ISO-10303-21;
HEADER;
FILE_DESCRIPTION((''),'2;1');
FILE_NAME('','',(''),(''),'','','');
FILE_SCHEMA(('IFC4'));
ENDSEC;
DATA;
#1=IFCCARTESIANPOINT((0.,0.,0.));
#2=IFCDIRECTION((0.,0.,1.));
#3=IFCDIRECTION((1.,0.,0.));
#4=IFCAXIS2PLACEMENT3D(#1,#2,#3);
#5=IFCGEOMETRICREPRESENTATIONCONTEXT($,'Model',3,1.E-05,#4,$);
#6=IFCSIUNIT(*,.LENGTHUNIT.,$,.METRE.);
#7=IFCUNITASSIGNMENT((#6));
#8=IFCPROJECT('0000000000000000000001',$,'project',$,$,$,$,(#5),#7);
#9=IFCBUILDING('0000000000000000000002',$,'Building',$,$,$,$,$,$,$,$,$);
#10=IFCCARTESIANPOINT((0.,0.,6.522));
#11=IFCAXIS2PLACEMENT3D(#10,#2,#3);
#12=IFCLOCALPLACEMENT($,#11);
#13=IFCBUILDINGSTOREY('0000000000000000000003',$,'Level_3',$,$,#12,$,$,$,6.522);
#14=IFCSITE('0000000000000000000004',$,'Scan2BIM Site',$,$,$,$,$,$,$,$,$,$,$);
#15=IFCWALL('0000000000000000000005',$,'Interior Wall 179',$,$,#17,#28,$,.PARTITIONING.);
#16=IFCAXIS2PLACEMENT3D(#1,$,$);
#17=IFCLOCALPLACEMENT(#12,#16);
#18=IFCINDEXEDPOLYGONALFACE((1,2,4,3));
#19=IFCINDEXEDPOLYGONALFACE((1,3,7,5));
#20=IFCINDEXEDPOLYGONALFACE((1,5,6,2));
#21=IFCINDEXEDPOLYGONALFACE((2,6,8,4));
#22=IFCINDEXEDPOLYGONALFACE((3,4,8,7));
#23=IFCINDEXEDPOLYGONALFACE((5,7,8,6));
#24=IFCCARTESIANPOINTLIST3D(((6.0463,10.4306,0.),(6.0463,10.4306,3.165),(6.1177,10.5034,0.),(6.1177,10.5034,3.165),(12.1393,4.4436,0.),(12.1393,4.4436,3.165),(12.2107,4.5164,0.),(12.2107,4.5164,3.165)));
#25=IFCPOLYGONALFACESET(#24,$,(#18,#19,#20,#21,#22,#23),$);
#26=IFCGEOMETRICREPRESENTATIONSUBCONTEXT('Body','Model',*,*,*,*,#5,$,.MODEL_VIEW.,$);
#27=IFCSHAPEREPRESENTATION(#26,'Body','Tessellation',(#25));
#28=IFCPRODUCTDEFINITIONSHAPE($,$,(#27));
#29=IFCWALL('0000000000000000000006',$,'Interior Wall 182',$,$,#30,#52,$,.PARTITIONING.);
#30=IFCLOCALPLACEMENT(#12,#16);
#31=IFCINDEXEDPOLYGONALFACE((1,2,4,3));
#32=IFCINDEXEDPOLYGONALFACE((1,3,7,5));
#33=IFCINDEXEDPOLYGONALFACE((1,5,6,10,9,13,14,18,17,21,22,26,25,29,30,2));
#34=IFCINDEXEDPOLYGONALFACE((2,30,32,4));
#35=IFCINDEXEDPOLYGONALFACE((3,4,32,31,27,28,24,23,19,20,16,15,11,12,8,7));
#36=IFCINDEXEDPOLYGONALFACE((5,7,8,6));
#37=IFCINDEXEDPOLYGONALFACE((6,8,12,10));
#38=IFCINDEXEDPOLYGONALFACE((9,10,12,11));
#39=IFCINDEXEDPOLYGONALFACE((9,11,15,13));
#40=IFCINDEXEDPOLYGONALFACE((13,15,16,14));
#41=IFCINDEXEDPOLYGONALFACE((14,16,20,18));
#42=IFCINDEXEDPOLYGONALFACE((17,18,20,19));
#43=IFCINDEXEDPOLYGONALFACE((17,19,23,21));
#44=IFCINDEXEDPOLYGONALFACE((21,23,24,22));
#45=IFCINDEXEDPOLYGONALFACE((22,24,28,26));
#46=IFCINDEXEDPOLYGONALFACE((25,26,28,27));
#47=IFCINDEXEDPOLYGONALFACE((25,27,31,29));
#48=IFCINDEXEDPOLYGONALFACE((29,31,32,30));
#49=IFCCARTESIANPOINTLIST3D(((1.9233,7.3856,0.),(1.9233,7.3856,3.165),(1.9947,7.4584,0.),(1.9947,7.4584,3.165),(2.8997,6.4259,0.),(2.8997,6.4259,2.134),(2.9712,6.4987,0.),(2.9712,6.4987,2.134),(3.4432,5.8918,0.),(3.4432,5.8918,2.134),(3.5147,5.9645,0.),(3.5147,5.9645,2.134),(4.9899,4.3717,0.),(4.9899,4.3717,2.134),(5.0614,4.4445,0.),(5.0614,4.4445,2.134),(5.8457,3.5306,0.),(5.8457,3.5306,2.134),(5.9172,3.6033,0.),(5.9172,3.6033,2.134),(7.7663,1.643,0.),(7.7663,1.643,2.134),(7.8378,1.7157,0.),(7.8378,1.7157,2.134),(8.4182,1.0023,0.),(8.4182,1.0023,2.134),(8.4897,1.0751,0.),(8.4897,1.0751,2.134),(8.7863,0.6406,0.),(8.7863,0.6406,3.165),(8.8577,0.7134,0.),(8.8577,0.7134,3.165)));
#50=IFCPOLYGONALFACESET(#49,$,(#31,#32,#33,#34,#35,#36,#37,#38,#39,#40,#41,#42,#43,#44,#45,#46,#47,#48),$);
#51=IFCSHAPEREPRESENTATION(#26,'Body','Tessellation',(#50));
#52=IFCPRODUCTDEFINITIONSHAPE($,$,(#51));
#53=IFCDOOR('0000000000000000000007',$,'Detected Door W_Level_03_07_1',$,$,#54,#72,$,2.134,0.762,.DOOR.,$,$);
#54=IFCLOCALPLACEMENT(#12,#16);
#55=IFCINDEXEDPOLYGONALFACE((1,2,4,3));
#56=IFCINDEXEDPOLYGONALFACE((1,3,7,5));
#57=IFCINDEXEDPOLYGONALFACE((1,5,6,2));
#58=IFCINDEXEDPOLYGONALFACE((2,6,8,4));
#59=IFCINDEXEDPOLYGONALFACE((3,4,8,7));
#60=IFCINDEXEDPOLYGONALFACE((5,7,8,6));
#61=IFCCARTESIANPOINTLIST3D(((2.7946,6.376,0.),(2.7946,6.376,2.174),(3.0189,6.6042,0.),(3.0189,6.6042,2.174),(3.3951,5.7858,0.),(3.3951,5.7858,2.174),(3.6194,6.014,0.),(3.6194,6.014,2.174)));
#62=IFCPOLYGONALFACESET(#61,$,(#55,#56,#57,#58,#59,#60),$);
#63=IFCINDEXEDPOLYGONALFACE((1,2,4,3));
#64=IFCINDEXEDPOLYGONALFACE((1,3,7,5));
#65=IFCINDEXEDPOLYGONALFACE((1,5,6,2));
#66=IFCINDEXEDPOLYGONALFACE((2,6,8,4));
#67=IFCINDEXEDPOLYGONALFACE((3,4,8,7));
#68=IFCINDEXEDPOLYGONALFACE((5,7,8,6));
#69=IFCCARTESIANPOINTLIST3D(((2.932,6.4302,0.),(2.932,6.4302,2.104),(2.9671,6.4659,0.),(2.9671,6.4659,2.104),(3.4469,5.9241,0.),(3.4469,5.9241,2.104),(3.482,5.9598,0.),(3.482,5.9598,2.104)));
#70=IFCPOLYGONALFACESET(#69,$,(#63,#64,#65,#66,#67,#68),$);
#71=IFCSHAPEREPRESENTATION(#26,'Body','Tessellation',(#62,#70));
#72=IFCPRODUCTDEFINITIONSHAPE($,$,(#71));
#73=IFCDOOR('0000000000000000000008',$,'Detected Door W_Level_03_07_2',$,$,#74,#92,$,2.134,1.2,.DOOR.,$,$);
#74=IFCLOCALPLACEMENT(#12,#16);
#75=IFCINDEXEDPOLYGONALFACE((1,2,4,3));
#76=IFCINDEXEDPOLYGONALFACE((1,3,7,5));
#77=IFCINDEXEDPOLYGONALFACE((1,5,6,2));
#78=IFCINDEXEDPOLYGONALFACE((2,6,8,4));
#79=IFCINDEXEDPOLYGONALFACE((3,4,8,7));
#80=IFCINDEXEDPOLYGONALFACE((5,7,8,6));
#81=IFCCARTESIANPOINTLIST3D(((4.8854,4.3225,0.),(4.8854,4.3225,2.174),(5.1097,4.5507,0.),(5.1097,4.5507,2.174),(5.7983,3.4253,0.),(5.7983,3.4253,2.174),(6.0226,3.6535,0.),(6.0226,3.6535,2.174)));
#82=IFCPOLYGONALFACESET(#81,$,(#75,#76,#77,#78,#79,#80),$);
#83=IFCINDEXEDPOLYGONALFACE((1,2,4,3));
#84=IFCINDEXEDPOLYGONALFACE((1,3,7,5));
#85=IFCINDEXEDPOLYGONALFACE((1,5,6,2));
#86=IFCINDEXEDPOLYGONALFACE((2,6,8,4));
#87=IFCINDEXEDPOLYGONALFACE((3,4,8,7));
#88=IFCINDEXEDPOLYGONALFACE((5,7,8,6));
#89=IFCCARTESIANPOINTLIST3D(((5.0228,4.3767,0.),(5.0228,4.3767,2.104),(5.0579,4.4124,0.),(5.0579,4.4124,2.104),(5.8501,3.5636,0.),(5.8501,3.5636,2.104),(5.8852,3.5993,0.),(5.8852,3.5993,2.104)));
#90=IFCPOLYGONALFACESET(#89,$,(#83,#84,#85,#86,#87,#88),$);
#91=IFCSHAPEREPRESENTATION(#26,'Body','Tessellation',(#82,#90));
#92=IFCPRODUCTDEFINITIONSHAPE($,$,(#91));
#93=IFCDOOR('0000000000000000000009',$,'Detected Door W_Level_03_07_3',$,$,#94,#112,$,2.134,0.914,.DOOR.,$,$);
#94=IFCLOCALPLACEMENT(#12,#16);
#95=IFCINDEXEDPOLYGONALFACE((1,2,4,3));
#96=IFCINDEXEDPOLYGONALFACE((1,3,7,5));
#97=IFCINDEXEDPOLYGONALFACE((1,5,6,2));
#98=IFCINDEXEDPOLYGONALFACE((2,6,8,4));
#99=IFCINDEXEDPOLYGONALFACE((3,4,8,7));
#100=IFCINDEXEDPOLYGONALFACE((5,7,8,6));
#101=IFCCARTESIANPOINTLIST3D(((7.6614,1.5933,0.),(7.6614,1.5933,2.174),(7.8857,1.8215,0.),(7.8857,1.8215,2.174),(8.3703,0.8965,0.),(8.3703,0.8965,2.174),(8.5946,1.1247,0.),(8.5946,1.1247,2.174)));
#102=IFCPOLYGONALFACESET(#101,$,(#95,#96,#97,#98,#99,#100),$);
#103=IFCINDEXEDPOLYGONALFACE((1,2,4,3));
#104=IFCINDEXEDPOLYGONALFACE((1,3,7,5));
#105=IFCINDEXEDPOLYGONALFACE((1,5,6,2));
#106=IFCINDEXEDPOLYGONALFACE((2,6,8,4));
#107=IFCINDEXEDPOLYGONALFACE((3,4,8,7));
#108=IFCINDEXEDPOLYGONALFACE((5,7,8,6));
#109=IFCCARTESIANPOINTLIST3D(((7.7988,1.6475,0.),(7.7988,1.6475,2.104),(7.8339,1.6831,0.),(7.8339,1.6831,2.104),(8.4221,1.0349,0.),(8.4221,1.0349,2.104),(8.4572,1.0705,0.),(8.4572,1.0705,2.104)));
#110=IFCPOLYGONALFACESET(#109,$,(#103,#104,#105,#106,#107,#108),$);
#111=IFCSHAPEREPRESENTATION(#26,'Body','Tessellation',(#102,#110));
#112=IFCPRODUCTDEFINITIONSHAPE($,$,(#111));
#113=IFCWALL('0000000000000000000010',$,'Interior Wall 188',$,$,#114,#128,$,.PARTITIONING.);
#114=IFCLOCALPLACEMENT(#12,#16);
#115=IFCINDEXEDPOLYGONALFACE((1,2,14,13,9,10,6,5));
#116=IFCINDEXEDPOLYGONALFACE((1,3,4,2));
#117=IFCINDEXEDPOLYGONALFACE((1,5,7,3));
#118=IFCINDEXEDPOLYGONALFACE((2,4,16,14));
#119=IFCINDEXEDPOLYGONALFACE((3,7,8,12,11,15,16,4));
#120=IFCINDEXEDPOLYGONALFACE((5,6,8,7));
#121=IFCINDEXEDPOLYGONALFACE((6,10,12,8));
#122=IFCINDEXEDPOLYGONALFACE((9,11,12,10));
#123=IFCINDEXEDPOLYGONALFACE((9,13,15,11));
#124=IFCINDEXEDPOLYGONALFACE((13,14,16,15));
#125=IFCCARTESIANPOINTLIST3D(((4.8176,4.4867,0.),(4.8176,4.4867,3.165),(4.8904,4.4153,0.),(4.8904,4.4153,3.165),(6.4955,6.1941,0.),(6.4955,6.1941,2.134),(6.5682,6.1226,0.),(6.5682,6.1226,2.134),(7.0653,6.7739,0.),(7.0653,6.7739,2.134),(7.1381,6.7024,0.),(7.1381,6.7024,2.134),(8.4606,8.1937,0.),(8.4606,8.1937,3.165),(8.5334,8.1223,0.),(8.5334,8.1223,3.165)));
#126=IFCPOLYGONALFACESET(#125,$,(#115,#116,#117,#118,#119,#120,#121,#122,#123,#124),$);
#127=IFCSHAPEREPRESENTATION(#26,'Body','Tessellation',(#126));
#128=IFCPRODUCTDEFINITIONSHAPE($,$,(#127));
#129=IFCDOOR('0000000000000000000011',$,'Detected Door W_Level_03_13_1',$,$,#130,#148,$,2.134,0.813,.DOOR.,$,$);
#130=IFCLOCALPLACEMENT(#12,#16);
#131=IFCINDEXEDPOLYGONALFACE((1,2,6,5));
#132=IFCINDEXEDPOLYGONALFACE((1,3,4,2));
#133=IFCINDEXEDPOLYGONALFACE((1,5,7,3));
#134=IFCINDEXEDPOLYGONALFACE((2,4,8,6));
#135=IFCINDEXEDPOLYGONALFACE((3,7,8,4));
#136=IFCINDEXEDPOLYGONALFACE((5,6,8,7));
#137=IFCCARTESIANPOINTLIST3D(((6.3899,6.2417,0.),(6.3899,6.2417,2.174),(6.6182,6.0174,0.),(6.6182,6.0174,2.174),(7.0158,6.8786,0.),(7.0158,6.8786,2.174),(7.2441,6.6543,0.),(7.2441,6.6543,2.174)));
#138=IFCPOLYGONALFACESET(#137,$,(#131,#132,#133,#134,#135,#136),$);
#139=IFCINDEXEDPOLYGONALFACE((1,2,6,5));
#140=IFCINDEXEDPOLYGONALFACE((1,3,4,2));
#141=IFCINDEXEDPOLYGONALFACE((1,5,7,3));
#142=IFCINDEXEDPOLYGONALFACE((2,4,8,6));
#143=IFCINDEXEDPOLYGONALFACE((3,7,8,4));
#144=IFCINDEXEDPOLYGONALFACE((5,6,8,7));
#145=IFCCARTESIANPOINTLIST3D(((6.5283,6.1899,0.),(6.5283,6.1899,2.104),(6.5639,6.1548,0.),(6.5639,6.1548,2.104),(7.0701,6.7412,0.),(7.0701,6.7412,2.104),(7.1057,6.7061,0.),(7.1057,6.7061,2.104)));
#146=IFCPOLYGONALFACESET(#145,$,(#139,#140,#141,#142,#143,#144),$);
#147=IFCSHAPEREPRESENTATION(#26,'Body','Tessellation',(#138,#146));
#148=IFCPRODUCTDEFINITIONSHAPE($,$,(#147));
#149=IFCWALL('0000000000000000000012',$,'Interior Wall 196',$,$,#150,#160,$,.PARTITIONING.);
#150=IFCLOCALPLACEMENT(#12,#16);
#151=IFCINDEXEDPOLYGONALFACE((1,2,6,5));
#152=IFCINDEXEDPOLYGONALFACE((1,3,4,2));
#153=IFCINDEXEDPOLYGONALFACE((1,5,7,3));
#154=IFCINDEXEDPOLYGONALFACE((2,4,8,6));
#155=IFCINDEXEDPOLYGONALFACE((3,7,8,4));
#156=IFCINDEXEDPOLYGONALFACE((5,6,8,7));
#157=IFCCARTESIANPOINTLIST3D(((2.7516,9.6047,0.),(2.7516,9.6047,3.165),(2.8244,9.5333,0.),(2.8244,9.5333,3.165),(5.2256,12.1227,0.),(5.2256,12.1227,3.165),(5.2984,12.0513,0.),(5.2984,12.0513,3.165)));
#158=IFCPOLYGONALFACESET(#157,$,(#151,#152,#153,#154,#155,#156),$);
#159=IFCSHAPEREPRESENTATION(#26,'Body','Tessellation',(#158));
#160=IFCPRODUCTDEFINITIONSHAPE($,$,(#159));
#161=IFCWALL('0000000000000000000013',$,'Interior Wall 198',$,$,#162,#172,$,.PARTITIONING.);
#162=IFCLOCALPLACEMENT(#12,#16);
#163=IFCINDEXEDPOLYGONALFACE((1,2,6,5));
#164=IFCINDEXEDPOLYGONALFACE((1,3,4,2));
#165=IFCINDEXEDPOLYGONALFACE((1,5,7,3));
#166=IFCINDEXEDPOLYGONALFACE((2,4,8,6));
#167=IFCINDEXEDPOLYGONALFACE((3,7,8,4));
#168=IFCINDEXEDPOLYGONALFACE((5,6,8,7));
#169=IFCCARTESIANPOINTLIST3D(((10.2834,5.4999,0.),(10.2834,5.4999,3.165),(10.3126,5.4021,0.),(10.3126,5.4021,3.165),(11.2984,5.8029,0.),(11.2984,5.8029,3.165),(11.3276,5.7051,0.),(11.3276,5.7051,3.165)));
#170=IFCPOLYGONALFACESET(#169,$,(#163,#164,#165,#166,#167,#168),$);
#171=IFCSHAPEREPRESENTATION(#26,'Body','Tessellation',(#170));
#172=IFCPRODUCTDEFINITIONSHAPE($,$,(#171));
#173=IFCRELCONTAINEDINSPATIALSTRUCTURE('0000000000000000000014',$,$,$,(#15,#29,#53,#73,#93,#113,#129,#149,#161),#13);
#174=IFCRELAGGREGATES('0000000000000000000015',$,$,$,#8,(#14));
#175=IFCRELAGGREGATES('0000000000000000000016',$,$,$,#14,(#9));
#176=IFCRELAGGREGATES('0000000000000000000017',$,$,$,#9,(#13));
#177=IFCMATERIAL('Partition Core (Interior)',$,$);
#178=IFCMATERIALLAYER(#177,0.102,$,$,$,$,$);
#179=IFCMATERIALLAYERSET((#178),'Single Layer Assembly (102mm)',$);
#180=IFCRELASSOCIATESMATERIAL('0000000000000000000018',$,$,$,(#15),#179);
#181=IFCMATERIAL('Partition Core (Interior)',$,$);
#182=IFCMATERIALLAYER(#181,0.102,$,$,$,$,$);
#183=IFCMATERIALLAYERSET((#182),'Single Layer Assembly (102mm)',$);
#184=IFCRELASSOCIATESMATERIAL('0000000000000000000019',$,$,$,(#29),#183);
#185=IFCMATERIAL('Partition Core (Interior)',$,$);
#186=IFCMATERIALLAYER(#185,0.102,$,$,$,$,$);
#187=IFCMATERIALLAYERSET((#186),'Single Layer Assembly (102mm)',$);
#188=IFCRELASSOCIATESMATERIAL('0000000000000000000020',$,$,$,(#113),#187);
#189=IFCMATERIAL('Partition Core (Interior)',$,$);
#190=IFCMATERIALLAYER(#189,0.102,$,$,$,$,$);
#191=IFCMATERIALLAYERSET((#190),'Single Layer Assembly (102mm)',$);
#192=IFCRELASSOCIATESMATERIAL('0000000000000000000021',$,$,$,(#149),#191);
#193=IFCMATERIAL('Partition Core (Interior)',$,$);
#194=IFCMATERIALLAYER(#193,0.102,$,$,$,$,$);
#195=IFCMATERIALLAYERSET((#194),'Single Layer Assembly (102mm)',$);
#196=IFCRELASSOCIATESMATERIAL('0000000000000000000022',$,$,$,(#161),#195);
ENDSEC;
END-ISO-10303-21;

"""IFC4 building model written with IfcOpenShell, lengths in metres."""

from ifc_helpers import new_model, si_unit, frame, origin, origin_with_axes, place, context, subcontext, project, spatial, rectangle, extrude, material, layer, layer_set, element, fill, save


model = new_model("IFC4")

# Units and contexts
model_context = context("Model", 3, precision=1e-05, world=origin_with_axes())
body_context = subcontext(model_context, "Body", "Model", "MODEL_VIEW")
ifc_project = project(units=[si_unit("LENGTHUNIT", "METRE")], contexts=[model_context])

# Site, building, storey
site = spatial("IfcSite", under=ifc_project, Name="Scan2BIM Site")
building = spatial("IfcBuilding", under=site, Name="Building")
storey_placement = place(None, frame((0.0, 0.0, 6.522), z_axis=(0.0, 0.0, 1.0), x_axis=(1.0, 0.0, 0.0)))
storey = spatial("IfcBuildingStorey", under=building, at=storey_placement, Name="Level_3", Elevation=6.522)

# Wall
ifc_material_1 = material(Name="Partition Core (Interior)")
ifc_layer_1 = layer(ifc_material_1, 0.102)
ifc_layer_set_1 = layer_set([ifc_layer_1], Name="Single Layer Assembly (102mm)")
wall_1_placement = place(storey_placement, frame((9.1285, 7.4735, 0.0), z_axis=(0.0, 0.0, 1.0), x_axis=(0.713284, -0.700875, 0.0)))
element("IfcWall", 1, at=wall_1_placement, inside=storey, material=ifc_layer_set_1, Name="Interior Wall 179", PredefinedType="PARTITIONING", context=body_context, shape_type="SweptSolid", body=[
    extrude(rectangle(XDim=8.5422, YDim=0.102), origin(), (0.0, 0.0, 1.0), 3.165),
])

# Wall, openings, doors
ifc_material_2 = material(Name="Partition Core (Interior)")
ifc_layer_2 = layer(ifc_material_2, 0.102)
ifc_layer_set_2 = layer_set([ifc_layer_2], Name="Single Layer Assembly (102mm)")
wall_2_placement = place(storey_placement, frame((5.3905, 4.0495, 0.0), z_axis=(0.0, 0.0, 1.0), x_axis=(0.713212, -0.700949, 0.0)))
wall_2 = element("IfcWall", 2, at=wall_2_placement, inside=storey, material=ifc_layer_set_2, Name="Interior Wall 182", PredefinedType="PARTITIONING", context=body_context, shape_type="SweptSolid", body=[
    extrude(rectangle(XDim=9.6227, YDim=0.102), origin(), (0.0, 0.0, 1.0), 3.165),
])
opening_1_placement = place(None, frame((3.207, 6.195, 6.522), z_axis=(0.0, 0.0, 1.0), x_axis=(0.713212, -0.700949, 0.0)))
opening_1 = element("IfcOpeningElement", 3, at=opening_1_placement, cuts=wall_2, PredefinedType="OPENING", context=body_context, shape_type="SweptSolid", body=[
    extrude(rectangle(XDim=0.762, YDim=0.202), origin(), (0.0, 0.0, 1.0), 2.134),
])
opening_2_placement = place(None, frame((5.454, 3.988, 6.522), z_axis=(0.0, 0.0, 1.0), x_axis=(0.713212, -0.700949, 0.0)))
opening_2 = element("IfcOpeningElement", 4, at=opening_2_placement, cuts=wall_2, PredefinedType="OPENING", context=body_context, shape_type="SweptSolid", body=[
    extrude(rectangle(XDim=1.2, YDim=0.202), origin(), (0.0, 0.0, 1.0), 2.134),
])
opening_3_placement = place(None, frame((8.128, 1.359, 6.522), z_axis=(0.0, 0.0, 1.0), x_axis=(0.713212, -0.700949, 0.0)))
opening_3 = element("IfcOpeningElement", 5, at=opening_3_placement, cuts=wall_2, PredefinedType="OPENING", context=body_context, shape_type="SweptSolid", body=[
    extrude(rectangle(XDim=0.914, YDim=0.202), origin(), (0.0, 0.0, 1.0), 2.134),
])
door_1_placement = place(opening_1_placement, frame((0.0, 0.0, 0.0), z_axis=(0.0, 0.0, 1.0), x_axis=(1.0, 0.0, 0.0)))
door_1 = element("IfcDoor", 6, at=door_1_placement, inside=storey, Name="Detected Door W_Level_03_07_1", OverallHeight=2.134, OverallWidth=0.762, PredefinedType="DOOR", context=body_context, shape_type="SweptSolid", body=[
    extrude(rectangle(XDim=0.842, YDim=0.32), origin(), (0.0, 0.0, 1.0), 2.174),
    extrude(rectangle(XDim=0.722, YDim=0.05), origin(), (0.0, 0.0, 1.0), 2.104),
])
fill(opening_1, door_1)
door_2_placement = place(opening_2_placement, frame((0.0, 0.0, 0.0), z_axis=(0.0, 0.0, 1.0), x_axis=(1.0, 0.0, 0.0)))
door_2 = element("IfcDoor", 7, at=door_2_placement, inside=storey, Name="Detected Door W_Level_03_07_2", OverallHeight=2.134, OverallWidth=1.2, PredefinedType="DOOR", context=body_context, shape_type="SweptSolid", body=[
    extrude(rectangle(XDim=1.28, YDim=0.32), origin(), (0.0, 0.0, 1.0), 2.174),
    extrude(rectangle(XDim=1.16, YDim=0.05), origin(), (0.0, 0.0, 1.0), 2.104),
])
fill(opening_2, door_2)
door_3_placement = place(opening_3_placement, frame((0.0, 0.0, 0.0), z_axis=(0.0, 0.0, 1.0), x_axis=(1.0, 0.0, 0.0)))
door_3 = element("IfcDoor", 8, at=door_3_placement, inside=storey, Name="Detected Door W_Level_03_07_3", OverallHeight=2.134, OverallWidth=0.914, PredefinedType="DOOR", context=body_context, shape_type="SweptSolid", body=[
    extrude(rectangle(XDim=0.994, YDim=0.32), origin(), (0.0, 0.0, 1.0), 2.174),
    extrude(rectangle(XDim=0.874, YDim=0.05), origin(), (0.0, 0.0, 1.0), 2.104),
])
fill(opening_3, door_3)

# Wall, opening, door
ifc_material_3 = material(Name="Partition Core (Interior)")
ifc_layer_3 = layer(ifc_material_3, 0.102)
ifc_layer_set_3 = layer_set([ifc_layer_3], Name="Single Layer Assembly (102mm)")
wall_3_placement = place(storey_placement, frame((6.6755, 6.3045, 0.0), z_axis=(0.0, 0.0, 1.0), x_axis=(0.700923, 0.713237, 0.0)))
wall_3 = element("IfcWall", 9, at=wall_3_placement, inside=storey, material=ifc_layer_set_3, Name="Interior Wall 188", PredefinedType="PARTITIONING", context=body_context, shape_type="SweptSolid", body=[
    extrude(rectangle(XDim=5.1974, YDim=0.102), origin(), (0.0, 0.0, 1.0), 3.165),
])
opening_4_placement = place(None, frame((6.817, 6.448, 6.522), z_axis=(0.0, 0.0, 1.0), x_axis=(0.700923, 0.713237, 0.0)))
opening_4 = element("IfcOpeningElement", 10, at=opening_4_placement, cuts=wall_3, PredefinedType="OPENING", context=body_context, shape_type="SweptSolid", body=[
    extrude(rectangle(XDim=0.813, YDim=0.202), origin(), (0.0, 0.0, 1.0), 2.134),
])
door_4_placement = place(opening_4_placement, frame((0.0, 0.0, 0.0), z_axis=(0.0, 0.0, 1.0), x_axis=(1.0, 0.0, 0.0)))
door_4 = element("IfcDoor", 11, at=door_4_placement, inside=storey, Name="Detected Door W_Level_03_13_1", OverallHeight=2.134, OverallWidth=0.813, PredefinedType="DOOR", context=body_context, shape_type="SweptSolid", body=[
    extrude(rectangle(XDim=0.893, YDim=0.32), origin(), (0.0, 0.0, 1.0), 2.174),
    extrude(rectangle(XDim=0.773, YDim=0.05), origin(), (0.0, 0.0, 1.0), 2.104),
])
fill(opening_4, door_4)

# Walls
ifc_material_4 = material(Name="Partition Core (Interior)")
ifc_layer_4 = layer(ifc_material_4, 0.102)
ifc_layer_set_4 = layer_set([ifc_layer_4], Name="Single Layer Assembly (102mm)")
wall_4_placement = place(storey_placement, frame((4.025, 10.828, 0.0), z_axis=(0.0, 0.0, 1.0), x_axis=(-0.700847, -0.713312, 0.0)))
element("IfcWall", 12, at=wall_4_placement, inside=storey, material=ifc_layer_set_4, Name="Interior Wall 196", PredefinedType="PARTITIONING", context=body_context, shape_type="SweptSolid", body=[
    extrude(rectangle(XDim=3.53, YDim=0.102), origin(), (0.0, 0.0, 1.0), 3.165),
])
ifc_material_5 = material(Name="Partition Core (Interior)")
ifc_layer_5 = layer(ifc_material_5, 0.102)
ifc_layer_set_5 = layer_set([ifc_layer_5], Name="Single Layer Assembly (102mm)")
wall_5_placement = place(storey_placement, frame((10.8055, 5.6025, 0.0), z_axis=(0.0, 0.0, 1.0), x_axis=(-0.958215, -0.286048, 0.0)))
element("IfcWall", 13, at=wall_5_placement, inside=storey, material=ifc_layer_set_5, Name="Interior Wall 198", PredefinedType="PARTITIONING", context=body_context, shape_type="SweptSolid", body=[
    extrude(rectangle(XDim=1.0593, YDim=0.102), origin(), (0.0, 0.0, 1.0), 3.165),
])

save(model, "model.ifc")
